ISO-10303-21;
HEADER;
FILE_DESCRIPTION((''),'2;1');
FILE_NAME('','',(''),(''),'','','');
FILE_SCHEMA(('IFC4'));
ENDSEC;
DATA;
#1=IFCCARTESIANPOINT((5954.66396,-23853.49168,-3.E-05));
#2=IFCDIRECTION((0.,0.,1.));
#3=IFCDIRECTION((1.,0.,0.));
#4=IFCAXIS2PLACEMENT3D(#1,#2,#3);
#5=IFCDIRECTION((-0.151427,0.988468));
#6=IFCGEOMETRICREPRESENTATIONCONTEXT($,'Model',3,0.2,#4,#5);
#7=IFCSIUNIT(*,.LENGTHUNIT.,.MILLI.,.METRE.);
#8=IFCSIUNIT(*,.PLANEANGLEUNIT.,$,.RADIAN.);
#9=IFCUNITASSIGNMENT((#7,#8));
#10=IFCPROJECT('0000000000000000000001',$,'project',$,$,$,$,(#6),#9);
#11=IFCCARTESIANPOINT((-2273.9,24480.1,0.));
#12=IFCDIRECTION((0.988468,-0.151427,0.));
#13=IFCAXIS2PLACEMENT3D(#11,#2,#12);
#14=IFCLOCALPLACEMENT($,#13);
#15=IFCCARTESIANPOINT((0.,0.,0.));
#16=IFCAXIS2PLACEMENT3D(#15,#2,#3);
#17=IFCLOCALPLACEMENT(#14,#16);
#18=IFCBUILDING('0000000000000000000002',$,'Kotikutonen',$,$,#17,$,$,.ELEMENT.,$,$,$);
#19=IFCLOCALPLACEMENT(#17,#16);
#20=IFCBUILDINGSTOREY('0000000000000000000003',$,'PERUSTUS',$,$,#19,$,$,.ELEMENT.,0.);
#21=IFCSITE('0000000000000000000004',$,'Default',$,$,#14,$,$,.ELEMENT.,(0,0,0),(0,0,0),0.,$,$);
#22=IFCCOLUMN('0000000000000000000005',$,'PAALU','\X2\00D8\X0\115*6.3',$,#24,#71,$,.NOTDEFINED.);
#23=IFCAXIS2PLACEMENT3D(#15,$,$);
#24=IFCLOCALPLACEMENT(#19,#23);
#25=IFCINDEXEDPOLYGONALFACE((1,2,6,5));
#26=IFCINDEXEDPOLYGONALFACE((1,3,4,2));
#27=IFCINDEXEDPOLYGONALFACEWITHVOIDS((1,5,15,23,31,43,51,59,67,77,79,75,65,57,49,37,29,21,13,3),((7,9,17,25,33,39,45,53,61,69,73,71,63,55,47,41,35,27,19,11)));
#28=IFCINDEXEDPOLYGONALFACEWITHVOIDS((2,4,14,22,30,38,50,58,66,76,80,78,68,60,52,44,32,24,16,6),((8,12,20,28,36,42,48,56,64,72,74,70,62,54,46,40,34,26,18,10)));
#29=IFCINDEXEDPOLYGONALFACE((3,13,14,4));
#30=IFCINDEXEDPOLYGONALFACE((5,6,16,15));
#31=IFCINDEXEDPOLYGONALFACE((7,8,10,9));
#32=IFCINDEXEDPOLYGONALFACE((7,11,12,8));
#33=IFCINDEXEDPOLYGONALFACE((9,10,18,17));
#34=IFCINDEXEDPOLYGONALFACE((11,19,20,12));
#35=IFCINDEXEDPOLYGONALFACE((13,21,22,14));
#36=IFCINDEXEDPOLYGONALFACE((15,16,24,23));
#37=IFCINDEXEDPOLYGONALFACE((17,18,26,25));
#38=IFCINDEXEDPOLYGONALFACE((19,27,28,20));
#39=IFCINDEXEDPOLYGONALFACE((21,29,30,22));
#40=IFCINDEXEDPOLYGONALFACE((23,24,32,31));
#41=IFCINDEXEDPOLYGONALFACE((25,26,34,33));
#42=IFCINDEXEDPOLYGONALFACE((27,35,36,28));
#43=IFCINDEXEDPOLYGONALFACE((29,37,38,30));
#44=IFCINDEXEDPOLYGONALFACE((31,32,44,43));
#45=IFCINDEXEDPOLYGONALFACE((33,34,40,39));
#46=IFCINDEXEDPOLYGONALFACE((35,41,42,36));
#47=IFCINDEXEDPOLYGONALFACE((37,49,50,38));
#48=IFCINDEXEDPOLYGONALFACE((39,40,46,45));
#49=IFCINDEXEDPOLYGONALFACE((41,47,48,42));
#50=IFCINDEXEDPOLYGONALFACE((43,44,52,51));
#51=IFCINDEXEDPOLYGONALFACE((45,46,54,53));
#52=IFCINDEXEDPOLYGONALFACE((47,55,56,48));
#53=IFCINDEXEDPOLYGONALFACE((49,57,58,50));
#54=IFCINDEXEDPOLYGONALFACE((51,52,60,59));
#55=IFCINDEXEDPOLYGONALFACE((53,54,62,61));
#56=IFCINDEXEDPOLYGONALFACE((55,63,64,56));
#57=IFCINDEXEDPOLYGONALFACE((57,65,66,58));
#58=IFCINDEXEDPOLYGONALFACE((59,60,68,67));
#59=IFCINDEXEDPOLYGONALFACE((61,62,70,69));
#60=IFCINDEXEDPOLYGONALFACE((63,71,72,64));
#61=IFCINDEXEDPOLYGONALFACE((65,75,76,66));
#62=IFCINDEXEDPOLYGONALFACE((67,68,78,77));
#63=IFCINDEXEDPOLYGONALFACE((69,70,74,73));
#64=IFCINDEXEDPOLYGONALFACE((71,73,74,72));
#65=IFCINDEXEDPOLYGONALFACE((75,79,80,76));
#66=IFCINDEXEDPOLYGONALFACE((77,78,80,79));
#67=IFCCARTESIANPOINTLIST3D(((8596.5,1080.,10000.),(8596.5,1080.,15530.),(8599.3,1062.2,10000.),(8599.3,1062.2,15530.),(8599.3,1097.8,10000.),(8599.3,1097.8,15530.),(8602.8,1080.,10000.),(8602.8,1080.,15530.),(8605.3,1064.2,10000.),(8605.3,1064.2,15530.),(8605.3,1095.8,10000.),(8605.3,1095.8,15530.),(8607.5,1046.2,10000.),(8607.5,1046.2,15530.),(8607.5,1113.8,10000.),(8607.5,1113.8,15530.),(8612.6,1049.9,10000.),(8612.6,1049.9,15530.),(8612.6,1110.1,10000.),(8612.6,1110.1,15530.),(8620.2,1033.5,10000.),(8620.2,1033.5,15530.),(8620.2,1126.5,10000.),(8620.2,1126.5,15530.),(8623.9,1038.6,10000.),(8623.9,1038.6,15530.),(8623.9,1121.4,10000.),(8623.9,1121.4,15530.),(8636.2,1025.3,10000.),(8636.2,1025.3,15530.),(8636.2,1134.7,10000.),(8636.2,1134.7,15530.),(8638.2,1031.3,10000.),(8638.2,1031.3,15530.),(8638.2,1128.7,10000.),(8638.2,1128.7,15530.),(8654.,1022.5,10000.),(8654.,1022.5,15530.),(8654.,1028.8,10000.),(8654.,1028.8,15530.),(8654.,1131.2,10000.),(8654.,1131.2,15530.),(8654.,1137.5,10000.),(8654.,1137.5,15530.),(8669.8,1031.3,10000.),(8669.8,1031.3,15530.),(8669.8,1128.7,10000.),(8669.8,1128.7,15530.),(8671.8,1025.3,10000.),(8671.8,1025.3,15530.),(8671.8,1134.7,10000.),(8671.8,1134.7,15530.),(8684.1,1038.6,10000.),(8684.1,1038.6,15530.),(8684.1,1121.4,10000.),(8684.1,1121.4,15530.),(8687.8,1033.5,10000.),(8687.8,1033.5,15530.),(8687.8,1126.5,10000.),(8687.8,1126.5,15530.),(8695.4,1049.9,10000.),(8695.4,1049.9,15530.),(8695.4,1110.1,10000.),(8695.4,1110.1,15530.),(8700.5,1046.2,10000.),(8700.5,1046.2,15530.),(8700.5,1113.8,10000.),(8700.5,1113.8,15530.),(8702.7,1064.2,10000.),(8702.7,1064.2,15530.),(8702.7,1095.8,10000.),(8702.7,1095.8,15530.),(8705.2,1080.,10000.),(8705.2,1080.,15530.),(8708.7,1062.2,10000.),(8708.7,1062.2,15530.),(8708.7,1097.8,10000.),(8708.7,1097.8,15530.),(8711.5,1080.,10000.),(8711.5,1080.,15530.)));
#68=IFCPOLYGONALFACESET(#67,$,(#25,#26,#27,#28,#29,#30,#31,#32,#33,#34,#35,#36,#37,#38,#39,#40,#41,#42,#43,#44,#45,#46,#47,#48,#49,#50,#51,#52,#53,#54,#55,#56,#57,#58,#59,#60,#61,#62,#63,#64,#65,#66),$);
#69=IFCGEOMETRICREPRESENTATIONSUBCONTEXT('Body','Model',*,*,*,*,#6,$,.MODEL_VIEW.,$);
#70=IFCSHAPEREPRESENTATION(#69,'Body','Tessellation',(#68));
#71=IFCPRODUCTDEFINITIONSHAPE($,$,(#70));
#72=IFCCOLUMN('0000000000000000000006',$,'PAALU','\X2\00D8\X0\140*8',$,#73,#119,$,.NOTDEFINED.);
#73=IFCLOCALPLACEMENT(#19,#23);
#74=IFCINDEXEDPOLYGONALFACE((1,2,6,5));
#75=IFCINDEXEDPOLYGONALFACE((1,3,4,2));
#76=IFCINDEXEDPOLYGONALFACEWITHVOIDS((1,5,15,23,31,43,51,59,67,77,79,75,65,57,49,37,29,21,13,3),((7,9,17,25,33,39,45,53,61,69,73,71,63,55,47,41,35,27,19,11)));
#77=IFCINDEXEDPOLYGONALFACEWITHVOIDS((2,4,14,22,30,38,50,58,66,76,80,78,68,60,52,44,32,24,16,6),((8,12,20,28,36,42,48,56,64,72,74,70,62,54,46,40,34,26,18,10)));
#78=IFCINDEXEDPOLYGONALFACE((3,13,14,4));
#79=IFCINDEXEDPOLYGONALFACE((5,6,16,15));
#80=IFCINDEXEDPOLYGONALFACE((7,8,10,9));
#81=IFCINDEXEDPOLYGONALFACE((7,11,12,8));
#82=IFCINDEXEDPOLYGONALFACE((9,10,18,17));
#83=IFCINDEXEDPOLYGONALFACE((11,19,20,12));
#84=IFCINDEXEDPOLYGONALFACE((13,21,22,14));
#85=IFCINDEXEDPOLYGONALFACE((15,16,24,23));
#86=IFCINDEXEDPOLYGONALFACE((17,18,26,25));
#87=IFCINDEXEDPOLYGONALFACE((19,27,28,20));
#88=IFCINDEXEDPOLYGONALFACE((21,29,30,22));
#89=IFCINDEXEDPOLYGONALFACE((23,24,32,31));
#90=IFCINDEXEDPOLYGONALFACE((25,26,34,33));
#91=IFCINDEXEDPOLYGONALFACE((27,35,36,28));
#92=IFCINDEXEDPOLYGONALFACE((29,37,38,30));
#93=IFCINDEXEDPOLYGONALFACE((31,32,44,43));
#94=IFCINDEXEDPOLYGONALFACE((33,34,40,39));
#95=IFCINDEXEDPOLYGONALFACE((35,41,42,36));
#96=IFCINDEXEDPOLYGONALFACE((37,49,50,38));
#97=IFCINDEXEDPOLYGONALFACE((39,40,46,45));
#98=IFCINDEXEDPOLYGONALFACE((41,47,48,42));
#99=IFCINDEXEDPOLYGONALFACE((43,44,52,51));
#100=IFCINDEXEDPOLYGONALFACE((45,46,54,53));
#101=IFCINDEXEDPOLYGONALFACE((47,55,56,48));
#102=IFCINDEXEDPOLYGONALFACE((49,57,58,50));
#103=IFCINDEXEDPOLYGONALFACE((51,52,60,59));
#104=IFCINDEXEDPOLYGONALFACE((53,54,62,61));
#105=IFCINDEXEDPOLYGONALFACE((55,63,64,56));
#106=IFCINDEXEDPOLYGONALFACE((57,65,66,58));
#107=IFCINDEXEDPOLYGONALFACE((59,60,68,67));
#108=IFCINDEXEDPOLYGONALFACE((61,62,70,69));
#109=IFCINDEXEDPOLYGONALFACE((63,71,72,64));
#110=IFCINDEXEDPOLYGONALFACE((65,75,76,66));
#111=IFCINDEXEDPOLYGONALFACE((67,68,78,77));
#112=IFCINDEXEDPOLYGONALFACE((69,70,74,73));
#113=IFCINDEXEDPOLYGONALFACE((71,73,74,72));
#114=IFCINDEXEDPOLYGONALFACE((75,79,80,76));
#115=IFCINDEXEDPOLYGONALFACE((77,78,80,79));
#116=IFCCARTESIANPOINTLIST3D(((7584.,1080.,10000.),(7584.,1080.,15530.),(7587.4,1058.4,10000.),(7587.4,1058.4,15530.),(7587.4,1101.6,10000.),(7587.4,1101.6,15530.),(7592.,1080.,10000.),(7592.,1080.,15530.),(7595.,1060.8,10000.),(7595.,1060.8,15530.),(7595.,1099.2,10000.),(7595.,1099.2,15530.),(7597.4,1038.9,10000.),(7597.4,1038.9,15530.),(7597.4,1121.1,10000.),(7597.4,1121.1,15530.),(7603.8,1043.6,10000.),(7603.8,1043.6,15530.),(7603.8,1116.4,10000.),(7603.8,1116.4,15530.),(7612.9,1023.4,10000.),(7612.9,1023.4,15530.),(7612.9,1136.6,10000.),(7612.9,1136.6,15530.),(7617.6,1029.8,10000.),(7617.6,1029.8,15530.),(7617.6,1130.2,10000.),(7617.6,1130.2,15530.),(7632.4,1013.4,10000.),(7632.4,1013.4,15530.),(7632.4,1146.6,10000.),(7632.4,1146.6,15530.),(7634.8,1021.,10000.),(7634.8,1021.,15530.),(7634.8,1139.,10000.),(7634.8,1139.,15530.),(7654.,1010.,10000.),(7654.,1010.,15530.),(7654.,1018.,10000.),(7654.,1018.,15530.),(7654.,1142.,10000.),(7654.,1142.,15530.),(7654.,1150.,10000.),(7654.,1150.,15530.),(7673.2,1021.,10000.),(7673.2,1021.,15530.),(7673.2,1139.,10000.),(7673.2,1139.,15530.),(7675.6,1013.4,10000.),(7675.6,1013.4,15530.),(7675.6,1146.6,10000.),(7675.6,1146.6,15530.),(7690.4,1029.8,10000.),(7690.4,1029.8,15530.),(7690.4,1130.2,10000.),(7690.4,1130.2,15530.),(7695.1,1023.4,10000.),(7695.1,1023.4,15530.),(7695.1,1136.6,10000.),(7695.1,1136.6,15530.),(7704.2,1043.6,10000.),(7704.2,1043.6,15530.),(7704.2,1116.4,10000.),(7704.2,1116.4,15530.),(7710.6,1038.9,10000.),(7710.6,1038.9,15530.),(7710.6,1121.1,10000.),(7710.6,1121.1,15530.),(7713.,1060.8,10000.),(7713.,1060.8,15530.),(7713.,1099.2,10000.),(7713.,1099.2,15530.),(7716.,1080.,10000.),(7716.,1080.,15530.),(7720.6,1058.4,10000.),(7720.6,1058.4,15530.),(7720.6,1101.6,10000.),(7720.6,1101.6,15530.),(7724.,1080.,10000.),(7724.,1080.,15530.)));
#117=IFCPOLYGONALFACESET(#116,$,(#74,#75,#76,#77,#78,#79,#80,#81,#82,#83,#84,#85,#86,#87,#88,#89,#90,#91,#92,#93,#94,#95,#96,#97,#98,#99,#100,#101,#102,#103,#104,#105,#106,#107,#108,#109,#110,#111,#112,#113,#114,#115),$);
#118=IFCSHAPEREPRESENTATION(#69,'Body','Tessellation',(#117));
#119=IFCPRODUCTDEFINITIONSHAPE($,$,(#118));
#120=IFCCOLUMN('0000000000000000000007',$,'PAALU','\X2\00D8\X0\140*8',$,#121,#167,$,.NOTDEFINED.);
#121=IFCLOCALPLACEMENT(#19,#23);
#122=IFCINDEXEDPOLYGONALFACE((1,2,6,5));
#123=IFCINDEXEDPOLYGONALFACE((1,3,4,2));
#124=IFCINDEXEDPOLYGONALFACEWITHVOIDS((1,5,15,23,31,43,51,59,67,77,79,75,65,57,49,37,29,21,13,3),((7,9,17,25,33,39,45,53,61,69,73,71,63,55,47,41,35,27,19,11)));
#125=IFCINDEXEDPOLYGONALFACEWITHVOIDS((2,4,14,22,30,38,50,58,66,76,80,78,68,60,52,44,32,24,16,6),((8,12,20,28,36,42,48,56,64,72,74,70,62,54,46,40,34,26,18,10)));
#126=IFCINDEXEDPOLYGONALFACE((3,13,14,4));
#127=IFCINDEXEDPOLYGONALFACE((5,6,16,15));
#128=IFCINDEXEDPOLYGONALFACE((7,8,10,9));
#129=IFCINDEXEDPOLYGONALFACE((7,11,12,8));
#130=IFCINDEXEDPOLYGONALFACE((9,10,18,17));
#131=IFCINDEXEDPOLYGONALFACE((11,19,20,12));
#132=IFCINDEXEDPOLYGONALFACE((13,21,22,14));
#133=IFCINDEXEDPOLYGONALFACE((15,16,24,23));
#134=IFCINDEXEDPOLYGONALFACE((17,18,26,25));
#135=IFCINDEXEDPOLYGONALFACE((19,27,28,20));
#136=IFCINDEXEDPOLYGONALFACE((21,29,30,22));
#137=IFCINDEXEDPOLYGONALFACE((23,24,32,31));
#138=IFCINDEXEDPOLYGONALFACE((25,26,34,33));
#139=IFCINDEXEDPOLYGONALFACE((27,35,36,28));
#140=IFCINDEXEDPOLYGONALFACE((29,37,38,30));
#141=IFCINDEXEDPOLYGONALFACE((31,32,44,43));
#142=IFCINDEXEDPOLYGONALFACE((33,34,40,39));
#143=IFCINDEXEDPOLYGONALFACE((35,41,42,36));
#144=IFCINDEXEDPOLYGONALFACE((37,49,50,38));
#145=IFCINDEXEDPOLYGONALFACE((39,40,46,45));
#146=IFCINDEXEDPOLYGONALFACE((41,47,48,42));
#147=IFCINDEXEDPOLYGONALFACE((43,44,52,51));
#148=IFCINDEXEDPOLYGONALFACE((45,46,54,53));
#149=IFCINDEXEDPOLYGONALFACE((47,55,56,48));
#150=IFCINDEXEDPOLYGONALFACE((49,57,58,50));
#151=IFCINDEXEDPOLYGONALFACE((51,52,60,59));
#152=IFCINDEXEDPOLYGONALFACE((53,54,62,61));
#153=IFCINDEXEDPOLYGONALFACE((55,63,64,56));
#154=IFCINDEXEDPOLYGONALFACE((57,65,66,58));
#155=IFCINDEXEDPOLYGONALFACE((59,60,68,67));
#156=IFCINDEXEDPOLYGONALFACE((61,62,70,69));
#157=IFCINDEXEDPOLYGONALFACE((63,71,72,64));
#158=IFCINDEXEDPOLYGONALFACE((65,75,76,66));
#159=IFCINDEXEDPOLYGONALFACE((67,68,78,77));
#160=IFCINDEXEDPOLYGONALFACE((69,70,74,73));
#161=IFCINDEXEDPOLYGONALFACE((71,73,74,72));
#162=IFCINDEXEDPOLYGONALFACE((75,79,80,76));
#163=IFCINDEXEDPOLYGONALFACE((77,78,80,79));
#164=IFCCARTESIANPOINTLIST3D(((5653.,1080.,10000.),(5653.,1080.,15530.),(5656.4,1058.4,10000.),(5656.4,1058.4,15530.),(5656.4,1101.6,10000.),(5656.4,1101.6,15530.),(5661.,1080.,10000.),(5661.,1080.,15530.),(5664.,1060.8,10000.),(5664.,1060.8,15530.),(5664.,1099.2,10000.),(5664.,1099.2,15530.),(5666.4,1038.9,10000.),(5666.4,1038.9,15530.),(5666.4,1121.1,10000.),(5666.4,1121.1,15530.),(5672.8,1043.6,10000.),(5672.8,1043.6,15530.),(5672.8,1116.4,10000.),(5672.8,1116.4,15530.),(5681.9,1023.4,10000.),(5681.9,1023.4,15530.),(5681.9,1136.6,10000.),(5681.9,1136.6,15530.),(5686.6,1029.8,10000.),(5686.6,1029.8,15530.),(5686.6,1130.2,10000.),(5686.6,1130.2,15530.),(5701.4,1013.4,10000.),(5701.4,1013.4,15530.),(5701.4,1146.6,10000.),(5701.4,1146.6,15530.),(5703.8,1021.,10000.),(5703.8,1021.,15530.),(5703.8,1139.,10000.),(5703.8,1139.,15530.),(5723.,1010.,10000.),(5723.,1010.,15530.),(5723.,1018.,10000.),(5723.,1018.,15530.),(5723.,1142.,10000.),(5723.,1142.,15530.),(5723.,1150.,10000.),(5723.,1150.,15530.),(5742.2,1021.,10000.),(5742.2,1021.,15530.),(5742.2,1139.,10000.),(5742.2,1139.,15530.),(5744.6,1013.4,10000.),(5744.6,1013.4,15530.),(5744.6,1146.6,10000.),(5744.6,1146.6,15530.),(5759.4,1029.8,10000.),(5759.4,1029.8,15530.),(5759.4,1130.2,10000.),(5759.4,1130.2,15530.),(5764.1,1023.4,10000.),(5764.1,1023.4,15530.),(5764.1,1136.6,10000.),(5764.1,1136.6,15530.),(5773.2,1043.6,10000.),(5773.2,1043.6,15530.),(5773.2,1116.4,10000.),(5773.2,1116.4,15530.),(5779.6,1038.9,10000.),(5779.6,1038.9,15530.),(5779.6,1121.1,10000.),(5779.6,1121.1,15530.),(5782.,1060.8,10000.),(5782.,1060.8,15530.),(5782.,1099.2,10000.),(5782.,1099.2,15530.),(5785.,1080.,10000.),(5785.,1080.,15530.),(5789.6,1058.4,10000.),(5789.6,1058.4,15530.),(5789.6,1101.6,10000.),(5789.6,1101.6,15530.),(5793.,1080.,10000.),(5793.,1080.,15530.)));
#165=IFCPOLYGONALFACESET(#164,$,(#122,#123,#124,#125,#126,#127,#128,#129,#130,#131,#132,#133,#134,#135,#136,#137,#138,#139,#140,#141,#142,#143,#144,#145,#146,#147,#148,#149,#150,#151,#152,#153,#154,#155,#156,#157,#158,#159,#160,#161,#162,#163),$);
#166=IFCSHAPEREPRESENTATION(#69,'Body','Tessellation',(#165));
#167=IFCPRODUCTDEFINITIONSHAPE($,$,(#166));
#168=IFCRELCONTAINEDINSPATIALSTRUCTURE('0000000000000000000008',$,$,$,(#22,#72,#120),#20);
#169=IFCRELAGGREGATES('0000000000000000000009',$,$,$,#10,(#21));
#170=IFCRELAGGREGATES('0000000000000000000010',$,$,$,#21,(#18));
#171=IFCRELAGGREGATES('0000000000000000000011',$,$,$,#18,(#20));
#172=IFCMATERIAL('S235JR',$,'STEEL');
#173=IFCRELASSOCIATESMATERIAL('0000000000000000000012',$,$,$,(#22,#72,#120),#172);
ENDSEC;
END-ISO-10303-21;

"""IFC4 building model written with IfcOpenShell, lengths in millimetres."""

from ifc_helpers import new_model, si_unit, direction, frame, origin_with_axes, place, context, subcontext, project, spatial, line, indexed_curve, outline, extrude, material, element, save


model = new_model("IFC4")

# Units and contexts
model_context = context("Model", 3, precision=0.2, world=frame((5954.66396, -23853.49168, -3e-05), z_axis=(0.0, 0.0, 1.0), x_axis=(1.0, 0.0, 0.0)), true_north=direction((-0.151427, 0.988468)))
body_context = subcontext(model_context, "Body", "Model", "MODEL_VIEW")
ifc_project = project(units=[si_unit("LENGTHUNIT", "METRE", prefix="MILLI"), si_unit("PLANEANGLEUNIT", "RADIAN")], contexts=[model_context])

# Site, building, storey
site_placement = place(None, frame((-2273.9, 24480.1, 0.0), z_axis=(0.0, 0.0, 1.0), x_axis=(0.988468, -0.151427, 0.0)))
site = spatial("IfcSite", under=ifc_project, at=site_placement, Name="Default", CompositionType="ELEMENT", RefLatitude=(0, 0, 0), RefLongitude=(0, 0, 0), RefElevation=0.0)
building_placement = place(site_placement, origin_with_axes())
building = spatial("IfcBuilding", under=site, at=building_placement, Name="Kotikutonen", CompositionType="ELEMENT")
storey_placement = place(building_placement, origin_with_axes())
storey = spatial("IfcBuildingStorey", under=building, at=storey_placement, Name="PERUSTUS", CompositionType="ELEMENT", Elevation=0.0)

# Columns
ifc_material = material(Name="S235JR", Category="STEEL")
for number, where, z_axis, x_axis, name in (
    (1, (8654.0, 1080.0, 10000.0), (-1.0, 0.0, 0.0), (0.0, 0.0, 1.0), "PAALU"),
):
    element("IfcColumn", number, at=place(storey_placement, frame(where, z_axis=z_axis, x_axis=x_axis)), inside=storey, material=ifc_material, Name=name, Description="Ø115*6.3", PredefinedType="NOTDEFINED", context=body_context, shape_type="SolidModel", body=[
        extrude(outline(indexed_curve([(57.5, 0.0), (54.7, 17.8), (46.5, 33.8), (33.8, 46.5), (17.8, 54.7), (0.0, 57.5), (-17.8, 54.7), (-33.8, 46.5), (-46.5, 33.8), (-54.7, 17.8), (-57.5, 0.0), (-54.7, -17.8), (-46.5, -33.8), (-33.8, -46.5), (-17.8, -54.7), (0.0, -57.5), (17.8, -54.7), (33.8, -46.5), (46.5, -33.8), (54.7, -17.8)], segments=[line(1, 2, 3, 4, 5, 6, 7, 8, 9, 10, 11, 12, 13, 14, 15, 16, 17, 18, 19, 20, 1)]), holes=[indexed_curve([(51.2, 0.0), (48.7, -15.8), (41.4, -30.1), (30.1, -41.4), (15.8, -48.7), (0.0, -51.2), (-15.8, -48.7), (-30.1, -41.4), (-41.4, -30.1), (-48.7, -15.8), (-51.2, 0.0), (-48.7, 15.8), (-41.4, 30.1), (-30.1, 41.4), (-15.8, 48.7), (0.0, 51.2), (15.8, 48.7), (30.1, 41.4), (41.4, 30.1), (48.7, 15.8)], segments=[line(1, 2, 3, 4, 5, 6, 7, 8, 9, 10, 11, 12, 13, 14, 15, 16, 17, 18, 19, 20, 1)])]), frame((0.0, 0.0, 0.0), z_axis=(-1.0, 0.0, 0.0), x_axis=(0.0, 0.0, 1.0)), (0.0, 0.0, -1.0), 5530.0),
    ])
for number, where, z_axis, x_axis, name in (
    (2, (7654.0, 1080.0, 10000.0), (-1.0, 0.0, 0.0), (0.0, 0.0, 1.0), "PAALU"),
    (3, (5723.0, 1080.0, 10000.0), (-1.0, 0.0, 0.0), (0.0, 0.0, 1.0), "PAALU"),
):
    element("IfcColumn", number, at=place(storey_placement, frame(where, z_axis=z_axis, x_axis=x_axis)), inside=storey, material=ifc_material, Name=name, Description="Ø140*8", PredefinedType="NOTDEFINED", context=body_context, shape_type="SolidModel", body=[
        extrude(outline(indexed_curve([(70.0, 0.0), (66.6, 21.6), (56.6, 41.1), (41.1, 56.6), (21.6, 66.6), (0.0, 70.0), (-21.6, 66.6), (-41.1, 56.6), (-56.6, 41.1), (-66.6, 21.6), (-70.0, 0.0), (-66.6, -21.6), (-56.6, -41.1), (-41.1, -56.6), (-21.6, -66.6), (0.0, -70.0), (21.6, -66.6), (41.1, -56.6), (56.6, -41.1), (66.6, -21.6)], segments=[line(1, 2, 3, 4, 5, 6, 7, 8, 9, 10, 11, 12, 13, 14, 15, 16, 17, 18, 19, 20, 1)]), holes=[indexed_curve([(62.0, 0.0), (59.0, -19.2), (50.2, -36.4), (36.4, -50.2), (19.2, -59.0), (0.0, -62.0), (-19.2, -59.0), (-36.4, -50.2), (-50.2, -36.4), (-59.0, -19.2), (-62.0, 0.0), (-59.0, 19.2), (-50.2, 36.4), (-36.4, 50.2), (-19.2, 59.0), (0.0, 62.0), (19.2, 59.0), (36.4, 50.2), (50.2, 36.4), (59.0, 19.2)], segments=[line(1, 2, 3, 4, 5, 6, 7, 8, 9, 10, 11, 12, 13, 14, 15, 16, 17, 18, 19, 20, 1)])]), frame((0.0, 0.0, 0.0), z_axis=(-1.0, 0.0, 0.0), x_axis=(0.0, 0.0, 1.0)), (0.0, 0.0, -1.0), 5530.0),
    ])

save(model, "model.ifc")
